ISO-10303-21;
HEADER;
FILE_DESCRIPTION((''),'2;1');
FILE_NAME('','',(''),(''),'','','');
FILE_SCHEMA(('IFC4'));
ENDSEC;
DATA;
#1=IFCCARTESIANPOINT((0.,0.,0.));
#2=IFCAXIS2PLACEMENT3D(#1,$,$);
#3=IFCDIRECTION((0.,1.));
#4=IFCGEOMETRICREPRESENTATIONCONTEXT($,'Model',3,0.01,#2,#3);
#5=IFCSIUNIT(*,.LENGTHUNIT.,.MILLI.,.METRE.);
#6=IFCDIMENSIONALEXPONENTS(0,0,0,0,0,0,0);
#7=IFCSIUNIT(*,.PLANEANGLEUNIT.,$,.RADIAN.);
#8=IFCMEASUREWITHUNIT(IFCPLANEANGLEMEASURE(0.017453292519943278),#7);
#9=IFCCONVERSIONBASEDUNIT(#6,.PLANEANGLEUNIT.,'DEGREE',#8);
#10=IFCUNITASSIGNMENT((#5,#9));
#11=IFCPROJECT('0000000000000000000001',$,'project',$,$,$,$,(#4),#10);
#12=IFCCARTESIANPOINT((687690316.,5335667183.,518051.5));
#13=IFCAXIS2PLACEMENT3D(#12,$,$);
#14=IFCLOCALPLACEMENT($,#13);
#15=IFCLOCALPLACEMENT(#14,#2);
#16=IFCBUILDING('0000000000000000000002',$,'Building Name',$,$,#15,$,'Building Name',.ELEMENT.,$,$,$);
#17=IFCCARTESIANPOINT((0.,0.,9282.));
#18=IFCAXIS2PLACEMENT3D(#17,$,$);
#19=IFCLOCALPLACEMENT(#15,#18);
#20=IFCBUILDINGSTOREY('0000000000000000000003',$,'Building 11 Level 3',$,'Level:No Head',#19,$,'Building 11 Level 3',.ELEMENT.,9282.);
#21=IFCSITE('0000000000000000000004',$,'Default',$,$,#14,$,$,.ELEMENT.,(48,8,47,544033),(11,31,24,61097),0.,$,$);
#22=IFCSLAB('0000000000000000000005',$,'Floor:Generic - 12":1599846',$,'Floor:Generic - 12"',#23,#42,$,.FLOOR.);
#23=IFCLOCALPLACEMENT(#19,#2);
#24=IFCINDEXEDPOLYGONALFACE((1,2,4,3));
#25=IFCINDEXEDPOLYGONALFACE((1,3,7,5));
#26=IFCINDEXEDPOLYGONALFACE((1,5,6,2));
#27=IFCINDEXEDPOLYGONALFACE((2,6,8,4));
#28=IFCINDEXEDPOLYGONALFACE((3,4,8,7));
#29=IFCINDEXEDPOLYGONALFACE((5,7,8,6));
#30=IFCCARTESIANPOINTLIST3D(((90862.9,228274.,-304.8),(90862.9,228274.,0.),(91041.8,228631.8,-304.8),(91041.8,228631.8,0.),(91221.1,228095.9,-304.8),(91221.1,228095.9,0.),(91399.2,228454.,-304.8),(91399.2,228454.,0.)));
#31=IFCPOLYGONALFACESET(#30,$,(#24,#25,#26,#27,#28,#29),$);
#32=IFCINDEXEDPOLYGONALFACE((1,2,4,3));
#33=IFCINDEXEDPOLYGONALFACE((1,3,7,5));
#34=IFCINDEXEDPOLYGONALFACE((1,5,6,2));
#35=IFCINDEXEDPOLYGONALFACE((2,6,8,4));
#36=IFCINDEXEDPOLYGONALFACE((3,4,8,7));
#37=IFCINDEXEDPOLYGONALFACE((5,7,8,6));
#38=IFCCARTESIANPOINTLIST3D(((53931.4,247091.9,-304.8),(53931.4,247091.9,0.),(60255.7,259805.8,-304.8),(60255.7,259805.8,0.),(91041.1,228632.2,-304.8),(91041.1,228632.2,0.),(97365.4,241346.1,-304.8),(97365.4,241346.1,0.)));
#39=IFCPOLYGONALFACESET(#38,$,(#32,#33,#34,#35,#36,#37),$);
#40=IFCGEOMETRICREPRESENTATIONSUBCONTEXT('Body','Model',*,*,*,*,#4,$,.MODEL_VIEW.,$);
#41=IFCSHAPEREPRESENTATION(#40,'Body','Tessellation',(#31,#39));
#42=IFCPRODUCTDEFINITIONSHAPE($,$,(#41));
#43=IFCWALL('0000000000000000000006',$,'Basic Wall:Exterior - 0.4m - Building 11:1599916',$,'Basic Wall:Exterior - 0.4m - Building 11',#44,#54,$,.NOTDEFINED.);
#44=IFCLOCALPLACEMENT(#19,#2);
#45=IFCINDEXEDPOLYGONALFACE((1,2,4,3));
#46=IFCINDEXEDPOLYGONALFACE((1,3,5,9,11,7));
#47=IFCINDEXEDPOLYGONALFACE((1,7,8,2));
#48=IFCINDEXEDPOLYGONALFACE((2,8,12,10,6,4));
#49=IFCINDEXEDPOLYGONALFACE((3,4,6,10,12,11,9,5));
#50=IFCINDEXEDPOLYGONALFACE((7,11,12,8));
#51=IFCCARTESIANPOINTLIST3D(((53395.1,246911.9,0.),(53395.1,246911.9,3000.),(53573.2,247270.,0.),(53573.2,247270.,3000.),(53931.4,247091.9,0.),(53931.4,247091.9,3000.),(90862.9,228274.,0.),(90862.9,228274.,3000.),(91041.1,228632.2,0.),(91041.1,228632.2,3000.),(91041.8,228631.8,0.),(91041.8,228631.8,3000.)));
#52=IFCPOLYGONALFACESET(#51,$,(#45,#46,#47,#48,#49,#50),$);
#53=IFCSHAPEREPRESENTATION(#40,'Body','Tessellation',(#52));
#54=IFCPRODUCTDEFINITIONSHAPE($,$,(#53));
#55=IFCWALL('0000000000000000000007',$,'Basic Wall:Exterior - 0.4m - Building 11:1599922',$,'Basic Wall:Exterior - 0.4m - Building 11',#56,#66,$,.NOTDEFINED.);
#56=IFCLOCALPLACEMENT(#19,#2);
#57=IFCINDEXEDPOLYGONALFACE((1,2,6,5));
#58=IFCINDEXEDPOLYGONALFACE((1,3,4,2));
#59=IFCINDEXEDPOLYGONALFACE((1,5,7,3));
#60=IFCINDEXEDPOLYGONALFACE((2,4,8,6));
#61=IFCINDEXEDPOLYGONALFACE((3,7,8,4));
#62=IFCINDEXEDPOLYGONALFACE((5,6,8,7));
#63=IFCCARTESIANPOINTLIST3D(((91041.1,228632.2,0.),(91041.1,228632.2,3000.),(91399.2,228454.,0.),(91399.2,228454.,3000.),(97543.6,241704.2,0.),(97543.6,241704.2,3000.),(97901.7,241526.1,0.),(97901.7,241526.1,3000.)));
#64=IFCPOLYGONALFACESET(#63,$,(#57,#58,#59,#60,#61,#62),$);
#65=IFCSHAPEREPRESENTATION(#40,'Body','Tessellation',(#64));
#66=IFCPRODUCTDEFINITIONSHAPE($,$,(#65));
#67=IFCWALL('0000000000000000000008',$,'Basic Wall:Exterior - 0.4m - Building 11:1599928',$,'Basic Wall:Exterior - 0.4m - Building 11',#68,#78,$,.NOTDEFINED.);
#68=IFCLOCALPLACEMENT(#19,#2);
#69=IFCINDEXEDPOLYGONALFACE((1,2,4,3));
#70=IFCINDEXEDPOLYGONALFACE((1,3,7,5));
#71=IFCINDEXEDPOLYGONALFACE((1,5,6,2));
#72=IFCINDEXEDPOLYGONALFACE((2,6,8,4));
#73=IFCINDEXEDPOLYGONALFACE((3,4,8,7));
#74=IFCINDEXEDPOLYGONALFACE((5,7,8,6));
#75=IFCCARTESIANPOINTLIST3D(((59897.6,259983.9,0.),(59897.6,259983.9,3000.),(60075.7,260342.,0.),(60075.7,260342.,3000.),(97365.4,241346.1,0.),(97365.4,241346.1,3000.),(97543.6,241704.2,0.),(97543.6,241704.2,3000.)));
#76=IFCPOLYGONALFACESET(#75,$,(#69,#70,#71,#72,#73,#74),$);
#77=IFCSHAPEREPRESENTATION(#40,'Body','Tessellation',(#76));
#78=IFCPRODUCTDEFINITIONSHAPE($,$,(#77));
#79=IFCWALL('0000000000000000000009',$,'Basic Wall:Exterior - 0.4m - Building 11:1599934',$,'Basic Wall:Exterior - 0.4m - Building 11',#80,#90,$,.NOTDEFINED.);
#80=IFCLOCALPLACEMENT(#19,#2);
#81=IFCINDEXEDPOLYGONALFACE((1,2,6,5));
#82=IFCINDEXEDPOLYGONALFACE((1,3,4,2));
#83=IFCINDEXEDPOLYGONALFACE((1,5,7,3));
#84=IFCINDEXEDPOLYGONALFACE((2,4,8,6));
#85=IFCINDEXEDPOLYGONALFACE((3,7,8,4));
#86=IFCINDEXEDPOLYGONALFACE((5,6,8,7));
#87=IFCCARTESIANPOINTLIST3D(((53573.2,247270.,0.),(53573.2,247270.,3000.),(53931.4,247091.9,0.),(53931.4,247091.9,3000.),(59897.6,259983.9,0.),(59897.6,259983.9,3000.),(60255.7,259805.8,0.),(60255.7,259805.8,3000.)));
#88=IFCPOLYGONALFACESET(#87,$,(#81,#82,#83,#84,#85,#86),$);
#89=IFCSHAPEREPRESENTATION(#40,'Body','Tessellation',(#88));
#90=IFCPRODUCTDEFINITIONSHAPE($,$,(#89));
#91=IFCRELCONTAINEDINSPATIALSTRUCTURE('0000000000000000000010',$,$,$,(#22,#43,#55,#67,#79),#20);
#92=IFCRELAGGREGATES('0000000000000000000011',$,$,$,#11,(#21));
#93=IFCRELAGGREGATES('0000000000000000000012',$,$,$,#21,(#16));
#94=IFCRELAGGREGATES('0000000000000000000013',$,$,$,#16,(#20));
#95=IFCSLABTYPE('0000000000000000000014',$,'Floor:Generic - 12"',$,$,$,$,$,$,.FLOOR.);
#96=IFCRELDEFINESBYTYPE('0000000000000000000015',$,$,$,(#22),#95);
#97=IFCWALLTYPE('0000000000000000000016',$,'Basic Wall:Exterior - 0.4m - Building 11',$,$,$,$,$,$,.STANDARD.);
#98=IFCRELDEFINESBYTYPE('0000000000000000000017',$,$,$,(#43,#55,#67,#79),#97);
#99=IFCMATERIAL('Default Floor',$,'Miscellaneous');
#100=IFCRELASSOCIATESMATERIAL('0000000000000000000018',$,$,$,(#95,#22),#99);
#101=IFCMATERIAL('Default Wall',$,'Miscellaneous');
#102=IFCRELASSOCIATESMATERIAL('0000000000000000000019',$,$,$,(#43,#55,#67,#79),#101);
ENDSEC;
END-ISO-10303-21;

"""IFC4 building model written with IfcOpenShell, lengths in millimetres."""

from ifc_helpers import new_model, entity, si_unit, converted_unit, direction, frame, origin, place, context, subcontext, project, spatial, indexed_curve, outline, extrude, material, type_object, element, save


model = new_model("IFC4")

# Units and contexts
model_context = context("Model", 3, precision=0.01, world=origin(), true_north=direction((0.0, 1.0)))
body_context = subcontext(model_context, "Body", "Model", "MODEL_VIEW")
ifc_project = project(units=[si_unit("LENGTHUNIT", "METRE", prefix="MILLI"), converted_unit("PLANEANGLEUNIT", "DEGREE", entity("IfcPlaneAngleMeasure", 0.017453292519943278), si_unit("PLANEANGLEUNIT", "RADIAN"), dimensions=[0, 0, 0, 0, 0, 0, 0])], contexts=[model_context])

# Site, building, storey
site_placement = place(None, frame((687690316.0, 5335667183.0, 518051.5)))
site = spatial("IfcSite", under=ifc_project, at=site_placement, Name="Default", CompositionType="ELEMENT", RefLatitude=(48, 8, 47, 544033), RefLongitude=(11, 31, 24, 61097), RefElevation=0.0)
building_placement = place(site_placement, origin())
building = spatial("IfcBuilding", under=site, at=building_placement, Name="Building Name", LongName="Building Name", CompositionType="ELEMENT")
storey_placement = place(building_placement, frame((0.0, 0.0, 9282.0)))
storey = spatial("IfcBuildingStorey", under=building, at=storey_placement, Name="Building 11 Level 3", ObjectType="Level:No Head", LongName="Building 11 Level 3", CompositionType="ELEMENT", Elevation=9282.0)

# Slab
ifc_material_1 = material(Name="Default Floor", Category="Miscellaneous")
slab_type = type_object("IfcSlabType", Name="Floor:Generic - 12\"", PredefinedType="FLOOR", material=ifc_material_1)
slab_placement = place(storey_placement, origin())
element("IfcSlab", 1, at=slab_placement, inside=storey, type_object=slab_type, material=ifc_material_1, Name="Floor:Generic - 12\":1599846", ObjectType="Floor:Generic - 12\"", PredefinedType="FLOOR", context=body_context, shape_type="SweptSolid", body=[
    extrude(outline(indexed_curve([(-199.6, -199.8), (200.4, -199.8), (199.6, 200.2), (-200.4, 199.4), (-199.6, -199.8)], self_intersect=False)), frame((91131.2, 228363.9, -304.8), z_axis=(0.0, 0.0, 1.0), x_axis=(-0.447226, -0.894421, 0.0)), (0.0, 0.0, 1.0), 304.8),
    extrude(outline(indexed_curve([(-20723.7, -7100.0), (20723.7, -7100.0), (20723.7, 7100.0), (-20723.7, 7100.0), (-20723.7, -7100.0)], self_intersect=False)), frame((75648.4, 244219.0, -304.8), z_axis=(0.0, 0.0, 1.0), x_axis=(-0.895344, 0.445376, 0.0)), (0.0, 0.0, 1.0), 304.8),
])

# Walls
ifc_material_2 = material(Name="Default Wall", Category="Miscellaneous")
wall_type = type_object("IfcWallType", Name="Basic Wall:Exterior - 0.4m - Building 11", PredefinedType="STANDARD")
wall_1_placement = place(storey_placement, frame((53484.2, 247091.0, 0.0), z_axis=(0.0, 0.0, 1.0), x_axis=(0.895344, -0.445376, 0.0)))
element("IfcWall", 2, at=wall_1_placement, inside=storey, type_object=wall_type, material=ifc_material_2, Name="Basic Wall:Exterior - 0.4m - Building 11:1599916", ObjectType="Basic Wall:Exterior - 0.4m - Building 11", PredefinedType="NOTDEFINED", context=body_context, shape_type="SweptSolid", body=[
    extrude(outline(indexed_curve([(41847.4, -200.0), (41848.3, 200.0), (41847.4, 200.0), (400.0, 200.0), (0.0, 200.0), (0.0, -200.0), (41847.4, -200.0)], self_intersect=False)), origin(), (0.0, 0.0, 1.0), 3000.0),
])
wall_2_placement = place(storey_placement, frame((91220.1, 228543.1, 0.0), z_axis=(0.0, 0.0, 1.0), x_axis=(0.445376, 0.895344, 0.0)))
element("IfcWall", 3, at=wall_2_placement, inside=storey, type_object=wall_type, material=ifc_material_2, Name="Basic Wall:Exterior - 0.4m - Building 11:1599922", ObjectType="Basic Wall:Exterior - 0.4m - Building 11", PredefinedType="NOTDEFINED", context=body_context, shape_type="SweptSolid", body=[
    extrude(outline(indexed_curve([(14600.0, 200.0), (0.0, 200.0), (0.0, -200.0), (14600.0, -200.0), (14600.0, 200.0)], self_intersect=False)), origin(), (0.0, 0.0, 1.0), 3000.0),
])
wall_3_placement = place(storey_placement, frame((97454.5, 241525.1, 0.0), z_axis=(0.0, 0.0, 1.0), x_axis=(-0.895344, 0.445376, 0.0)))
element("IfcWall", 4, at=wall_3_placement, inside=storey, type_object=wall_type, material=ifc_material_2, Name="Basic Wall:Exterior - 0.4m - Building 11:1599928", ObjectType="Basic Wall:Exterior - 0.4m - Building 11", PredefinedType="NOTDEFINED", context=body_context, shape_type="SweptSolid", body=[
    extrude(outline(indexed_curve([(41847.4, 200.0), (0.0, 200.0), (0.0, -200.0), (41847.4, -200.0), (41847.4, 200.0)], self_intersect=False)), origin(), (0.0, 0.0, 1.0), 3000.0),
])
wall_4_placement = place(storey_placement, frame((60076.6, 259894.8, 0.0), z_axis=(0.0, 0.0, 1.0), x_axis=(-0.445376, -0.895344, 0.0)))
element("IfcWall", 5, at=wall_4_placement, inside=storey, type_object=wall_type, material=ifc_material_2, Name="Basic Wall:Exterior - 0.4m - Building 11:1599934", ObjectType="Basic Wall:Exterior - 0.4m - Building 11", PredefinedType="NOTDEFINED", context=body_context, shape_type="SweptSolid", body=[
    extrude(outline(indexed_curve([(14200.0, 200.0), (0.0, 200.0), (0.0, -200.0), (14200.0, -200.0), (14200.0, 200.0)], self_intersect=False)), origin(), (0.0, 0.0, 1.0), 3000.0),
])

save(model, "model.ifc")
